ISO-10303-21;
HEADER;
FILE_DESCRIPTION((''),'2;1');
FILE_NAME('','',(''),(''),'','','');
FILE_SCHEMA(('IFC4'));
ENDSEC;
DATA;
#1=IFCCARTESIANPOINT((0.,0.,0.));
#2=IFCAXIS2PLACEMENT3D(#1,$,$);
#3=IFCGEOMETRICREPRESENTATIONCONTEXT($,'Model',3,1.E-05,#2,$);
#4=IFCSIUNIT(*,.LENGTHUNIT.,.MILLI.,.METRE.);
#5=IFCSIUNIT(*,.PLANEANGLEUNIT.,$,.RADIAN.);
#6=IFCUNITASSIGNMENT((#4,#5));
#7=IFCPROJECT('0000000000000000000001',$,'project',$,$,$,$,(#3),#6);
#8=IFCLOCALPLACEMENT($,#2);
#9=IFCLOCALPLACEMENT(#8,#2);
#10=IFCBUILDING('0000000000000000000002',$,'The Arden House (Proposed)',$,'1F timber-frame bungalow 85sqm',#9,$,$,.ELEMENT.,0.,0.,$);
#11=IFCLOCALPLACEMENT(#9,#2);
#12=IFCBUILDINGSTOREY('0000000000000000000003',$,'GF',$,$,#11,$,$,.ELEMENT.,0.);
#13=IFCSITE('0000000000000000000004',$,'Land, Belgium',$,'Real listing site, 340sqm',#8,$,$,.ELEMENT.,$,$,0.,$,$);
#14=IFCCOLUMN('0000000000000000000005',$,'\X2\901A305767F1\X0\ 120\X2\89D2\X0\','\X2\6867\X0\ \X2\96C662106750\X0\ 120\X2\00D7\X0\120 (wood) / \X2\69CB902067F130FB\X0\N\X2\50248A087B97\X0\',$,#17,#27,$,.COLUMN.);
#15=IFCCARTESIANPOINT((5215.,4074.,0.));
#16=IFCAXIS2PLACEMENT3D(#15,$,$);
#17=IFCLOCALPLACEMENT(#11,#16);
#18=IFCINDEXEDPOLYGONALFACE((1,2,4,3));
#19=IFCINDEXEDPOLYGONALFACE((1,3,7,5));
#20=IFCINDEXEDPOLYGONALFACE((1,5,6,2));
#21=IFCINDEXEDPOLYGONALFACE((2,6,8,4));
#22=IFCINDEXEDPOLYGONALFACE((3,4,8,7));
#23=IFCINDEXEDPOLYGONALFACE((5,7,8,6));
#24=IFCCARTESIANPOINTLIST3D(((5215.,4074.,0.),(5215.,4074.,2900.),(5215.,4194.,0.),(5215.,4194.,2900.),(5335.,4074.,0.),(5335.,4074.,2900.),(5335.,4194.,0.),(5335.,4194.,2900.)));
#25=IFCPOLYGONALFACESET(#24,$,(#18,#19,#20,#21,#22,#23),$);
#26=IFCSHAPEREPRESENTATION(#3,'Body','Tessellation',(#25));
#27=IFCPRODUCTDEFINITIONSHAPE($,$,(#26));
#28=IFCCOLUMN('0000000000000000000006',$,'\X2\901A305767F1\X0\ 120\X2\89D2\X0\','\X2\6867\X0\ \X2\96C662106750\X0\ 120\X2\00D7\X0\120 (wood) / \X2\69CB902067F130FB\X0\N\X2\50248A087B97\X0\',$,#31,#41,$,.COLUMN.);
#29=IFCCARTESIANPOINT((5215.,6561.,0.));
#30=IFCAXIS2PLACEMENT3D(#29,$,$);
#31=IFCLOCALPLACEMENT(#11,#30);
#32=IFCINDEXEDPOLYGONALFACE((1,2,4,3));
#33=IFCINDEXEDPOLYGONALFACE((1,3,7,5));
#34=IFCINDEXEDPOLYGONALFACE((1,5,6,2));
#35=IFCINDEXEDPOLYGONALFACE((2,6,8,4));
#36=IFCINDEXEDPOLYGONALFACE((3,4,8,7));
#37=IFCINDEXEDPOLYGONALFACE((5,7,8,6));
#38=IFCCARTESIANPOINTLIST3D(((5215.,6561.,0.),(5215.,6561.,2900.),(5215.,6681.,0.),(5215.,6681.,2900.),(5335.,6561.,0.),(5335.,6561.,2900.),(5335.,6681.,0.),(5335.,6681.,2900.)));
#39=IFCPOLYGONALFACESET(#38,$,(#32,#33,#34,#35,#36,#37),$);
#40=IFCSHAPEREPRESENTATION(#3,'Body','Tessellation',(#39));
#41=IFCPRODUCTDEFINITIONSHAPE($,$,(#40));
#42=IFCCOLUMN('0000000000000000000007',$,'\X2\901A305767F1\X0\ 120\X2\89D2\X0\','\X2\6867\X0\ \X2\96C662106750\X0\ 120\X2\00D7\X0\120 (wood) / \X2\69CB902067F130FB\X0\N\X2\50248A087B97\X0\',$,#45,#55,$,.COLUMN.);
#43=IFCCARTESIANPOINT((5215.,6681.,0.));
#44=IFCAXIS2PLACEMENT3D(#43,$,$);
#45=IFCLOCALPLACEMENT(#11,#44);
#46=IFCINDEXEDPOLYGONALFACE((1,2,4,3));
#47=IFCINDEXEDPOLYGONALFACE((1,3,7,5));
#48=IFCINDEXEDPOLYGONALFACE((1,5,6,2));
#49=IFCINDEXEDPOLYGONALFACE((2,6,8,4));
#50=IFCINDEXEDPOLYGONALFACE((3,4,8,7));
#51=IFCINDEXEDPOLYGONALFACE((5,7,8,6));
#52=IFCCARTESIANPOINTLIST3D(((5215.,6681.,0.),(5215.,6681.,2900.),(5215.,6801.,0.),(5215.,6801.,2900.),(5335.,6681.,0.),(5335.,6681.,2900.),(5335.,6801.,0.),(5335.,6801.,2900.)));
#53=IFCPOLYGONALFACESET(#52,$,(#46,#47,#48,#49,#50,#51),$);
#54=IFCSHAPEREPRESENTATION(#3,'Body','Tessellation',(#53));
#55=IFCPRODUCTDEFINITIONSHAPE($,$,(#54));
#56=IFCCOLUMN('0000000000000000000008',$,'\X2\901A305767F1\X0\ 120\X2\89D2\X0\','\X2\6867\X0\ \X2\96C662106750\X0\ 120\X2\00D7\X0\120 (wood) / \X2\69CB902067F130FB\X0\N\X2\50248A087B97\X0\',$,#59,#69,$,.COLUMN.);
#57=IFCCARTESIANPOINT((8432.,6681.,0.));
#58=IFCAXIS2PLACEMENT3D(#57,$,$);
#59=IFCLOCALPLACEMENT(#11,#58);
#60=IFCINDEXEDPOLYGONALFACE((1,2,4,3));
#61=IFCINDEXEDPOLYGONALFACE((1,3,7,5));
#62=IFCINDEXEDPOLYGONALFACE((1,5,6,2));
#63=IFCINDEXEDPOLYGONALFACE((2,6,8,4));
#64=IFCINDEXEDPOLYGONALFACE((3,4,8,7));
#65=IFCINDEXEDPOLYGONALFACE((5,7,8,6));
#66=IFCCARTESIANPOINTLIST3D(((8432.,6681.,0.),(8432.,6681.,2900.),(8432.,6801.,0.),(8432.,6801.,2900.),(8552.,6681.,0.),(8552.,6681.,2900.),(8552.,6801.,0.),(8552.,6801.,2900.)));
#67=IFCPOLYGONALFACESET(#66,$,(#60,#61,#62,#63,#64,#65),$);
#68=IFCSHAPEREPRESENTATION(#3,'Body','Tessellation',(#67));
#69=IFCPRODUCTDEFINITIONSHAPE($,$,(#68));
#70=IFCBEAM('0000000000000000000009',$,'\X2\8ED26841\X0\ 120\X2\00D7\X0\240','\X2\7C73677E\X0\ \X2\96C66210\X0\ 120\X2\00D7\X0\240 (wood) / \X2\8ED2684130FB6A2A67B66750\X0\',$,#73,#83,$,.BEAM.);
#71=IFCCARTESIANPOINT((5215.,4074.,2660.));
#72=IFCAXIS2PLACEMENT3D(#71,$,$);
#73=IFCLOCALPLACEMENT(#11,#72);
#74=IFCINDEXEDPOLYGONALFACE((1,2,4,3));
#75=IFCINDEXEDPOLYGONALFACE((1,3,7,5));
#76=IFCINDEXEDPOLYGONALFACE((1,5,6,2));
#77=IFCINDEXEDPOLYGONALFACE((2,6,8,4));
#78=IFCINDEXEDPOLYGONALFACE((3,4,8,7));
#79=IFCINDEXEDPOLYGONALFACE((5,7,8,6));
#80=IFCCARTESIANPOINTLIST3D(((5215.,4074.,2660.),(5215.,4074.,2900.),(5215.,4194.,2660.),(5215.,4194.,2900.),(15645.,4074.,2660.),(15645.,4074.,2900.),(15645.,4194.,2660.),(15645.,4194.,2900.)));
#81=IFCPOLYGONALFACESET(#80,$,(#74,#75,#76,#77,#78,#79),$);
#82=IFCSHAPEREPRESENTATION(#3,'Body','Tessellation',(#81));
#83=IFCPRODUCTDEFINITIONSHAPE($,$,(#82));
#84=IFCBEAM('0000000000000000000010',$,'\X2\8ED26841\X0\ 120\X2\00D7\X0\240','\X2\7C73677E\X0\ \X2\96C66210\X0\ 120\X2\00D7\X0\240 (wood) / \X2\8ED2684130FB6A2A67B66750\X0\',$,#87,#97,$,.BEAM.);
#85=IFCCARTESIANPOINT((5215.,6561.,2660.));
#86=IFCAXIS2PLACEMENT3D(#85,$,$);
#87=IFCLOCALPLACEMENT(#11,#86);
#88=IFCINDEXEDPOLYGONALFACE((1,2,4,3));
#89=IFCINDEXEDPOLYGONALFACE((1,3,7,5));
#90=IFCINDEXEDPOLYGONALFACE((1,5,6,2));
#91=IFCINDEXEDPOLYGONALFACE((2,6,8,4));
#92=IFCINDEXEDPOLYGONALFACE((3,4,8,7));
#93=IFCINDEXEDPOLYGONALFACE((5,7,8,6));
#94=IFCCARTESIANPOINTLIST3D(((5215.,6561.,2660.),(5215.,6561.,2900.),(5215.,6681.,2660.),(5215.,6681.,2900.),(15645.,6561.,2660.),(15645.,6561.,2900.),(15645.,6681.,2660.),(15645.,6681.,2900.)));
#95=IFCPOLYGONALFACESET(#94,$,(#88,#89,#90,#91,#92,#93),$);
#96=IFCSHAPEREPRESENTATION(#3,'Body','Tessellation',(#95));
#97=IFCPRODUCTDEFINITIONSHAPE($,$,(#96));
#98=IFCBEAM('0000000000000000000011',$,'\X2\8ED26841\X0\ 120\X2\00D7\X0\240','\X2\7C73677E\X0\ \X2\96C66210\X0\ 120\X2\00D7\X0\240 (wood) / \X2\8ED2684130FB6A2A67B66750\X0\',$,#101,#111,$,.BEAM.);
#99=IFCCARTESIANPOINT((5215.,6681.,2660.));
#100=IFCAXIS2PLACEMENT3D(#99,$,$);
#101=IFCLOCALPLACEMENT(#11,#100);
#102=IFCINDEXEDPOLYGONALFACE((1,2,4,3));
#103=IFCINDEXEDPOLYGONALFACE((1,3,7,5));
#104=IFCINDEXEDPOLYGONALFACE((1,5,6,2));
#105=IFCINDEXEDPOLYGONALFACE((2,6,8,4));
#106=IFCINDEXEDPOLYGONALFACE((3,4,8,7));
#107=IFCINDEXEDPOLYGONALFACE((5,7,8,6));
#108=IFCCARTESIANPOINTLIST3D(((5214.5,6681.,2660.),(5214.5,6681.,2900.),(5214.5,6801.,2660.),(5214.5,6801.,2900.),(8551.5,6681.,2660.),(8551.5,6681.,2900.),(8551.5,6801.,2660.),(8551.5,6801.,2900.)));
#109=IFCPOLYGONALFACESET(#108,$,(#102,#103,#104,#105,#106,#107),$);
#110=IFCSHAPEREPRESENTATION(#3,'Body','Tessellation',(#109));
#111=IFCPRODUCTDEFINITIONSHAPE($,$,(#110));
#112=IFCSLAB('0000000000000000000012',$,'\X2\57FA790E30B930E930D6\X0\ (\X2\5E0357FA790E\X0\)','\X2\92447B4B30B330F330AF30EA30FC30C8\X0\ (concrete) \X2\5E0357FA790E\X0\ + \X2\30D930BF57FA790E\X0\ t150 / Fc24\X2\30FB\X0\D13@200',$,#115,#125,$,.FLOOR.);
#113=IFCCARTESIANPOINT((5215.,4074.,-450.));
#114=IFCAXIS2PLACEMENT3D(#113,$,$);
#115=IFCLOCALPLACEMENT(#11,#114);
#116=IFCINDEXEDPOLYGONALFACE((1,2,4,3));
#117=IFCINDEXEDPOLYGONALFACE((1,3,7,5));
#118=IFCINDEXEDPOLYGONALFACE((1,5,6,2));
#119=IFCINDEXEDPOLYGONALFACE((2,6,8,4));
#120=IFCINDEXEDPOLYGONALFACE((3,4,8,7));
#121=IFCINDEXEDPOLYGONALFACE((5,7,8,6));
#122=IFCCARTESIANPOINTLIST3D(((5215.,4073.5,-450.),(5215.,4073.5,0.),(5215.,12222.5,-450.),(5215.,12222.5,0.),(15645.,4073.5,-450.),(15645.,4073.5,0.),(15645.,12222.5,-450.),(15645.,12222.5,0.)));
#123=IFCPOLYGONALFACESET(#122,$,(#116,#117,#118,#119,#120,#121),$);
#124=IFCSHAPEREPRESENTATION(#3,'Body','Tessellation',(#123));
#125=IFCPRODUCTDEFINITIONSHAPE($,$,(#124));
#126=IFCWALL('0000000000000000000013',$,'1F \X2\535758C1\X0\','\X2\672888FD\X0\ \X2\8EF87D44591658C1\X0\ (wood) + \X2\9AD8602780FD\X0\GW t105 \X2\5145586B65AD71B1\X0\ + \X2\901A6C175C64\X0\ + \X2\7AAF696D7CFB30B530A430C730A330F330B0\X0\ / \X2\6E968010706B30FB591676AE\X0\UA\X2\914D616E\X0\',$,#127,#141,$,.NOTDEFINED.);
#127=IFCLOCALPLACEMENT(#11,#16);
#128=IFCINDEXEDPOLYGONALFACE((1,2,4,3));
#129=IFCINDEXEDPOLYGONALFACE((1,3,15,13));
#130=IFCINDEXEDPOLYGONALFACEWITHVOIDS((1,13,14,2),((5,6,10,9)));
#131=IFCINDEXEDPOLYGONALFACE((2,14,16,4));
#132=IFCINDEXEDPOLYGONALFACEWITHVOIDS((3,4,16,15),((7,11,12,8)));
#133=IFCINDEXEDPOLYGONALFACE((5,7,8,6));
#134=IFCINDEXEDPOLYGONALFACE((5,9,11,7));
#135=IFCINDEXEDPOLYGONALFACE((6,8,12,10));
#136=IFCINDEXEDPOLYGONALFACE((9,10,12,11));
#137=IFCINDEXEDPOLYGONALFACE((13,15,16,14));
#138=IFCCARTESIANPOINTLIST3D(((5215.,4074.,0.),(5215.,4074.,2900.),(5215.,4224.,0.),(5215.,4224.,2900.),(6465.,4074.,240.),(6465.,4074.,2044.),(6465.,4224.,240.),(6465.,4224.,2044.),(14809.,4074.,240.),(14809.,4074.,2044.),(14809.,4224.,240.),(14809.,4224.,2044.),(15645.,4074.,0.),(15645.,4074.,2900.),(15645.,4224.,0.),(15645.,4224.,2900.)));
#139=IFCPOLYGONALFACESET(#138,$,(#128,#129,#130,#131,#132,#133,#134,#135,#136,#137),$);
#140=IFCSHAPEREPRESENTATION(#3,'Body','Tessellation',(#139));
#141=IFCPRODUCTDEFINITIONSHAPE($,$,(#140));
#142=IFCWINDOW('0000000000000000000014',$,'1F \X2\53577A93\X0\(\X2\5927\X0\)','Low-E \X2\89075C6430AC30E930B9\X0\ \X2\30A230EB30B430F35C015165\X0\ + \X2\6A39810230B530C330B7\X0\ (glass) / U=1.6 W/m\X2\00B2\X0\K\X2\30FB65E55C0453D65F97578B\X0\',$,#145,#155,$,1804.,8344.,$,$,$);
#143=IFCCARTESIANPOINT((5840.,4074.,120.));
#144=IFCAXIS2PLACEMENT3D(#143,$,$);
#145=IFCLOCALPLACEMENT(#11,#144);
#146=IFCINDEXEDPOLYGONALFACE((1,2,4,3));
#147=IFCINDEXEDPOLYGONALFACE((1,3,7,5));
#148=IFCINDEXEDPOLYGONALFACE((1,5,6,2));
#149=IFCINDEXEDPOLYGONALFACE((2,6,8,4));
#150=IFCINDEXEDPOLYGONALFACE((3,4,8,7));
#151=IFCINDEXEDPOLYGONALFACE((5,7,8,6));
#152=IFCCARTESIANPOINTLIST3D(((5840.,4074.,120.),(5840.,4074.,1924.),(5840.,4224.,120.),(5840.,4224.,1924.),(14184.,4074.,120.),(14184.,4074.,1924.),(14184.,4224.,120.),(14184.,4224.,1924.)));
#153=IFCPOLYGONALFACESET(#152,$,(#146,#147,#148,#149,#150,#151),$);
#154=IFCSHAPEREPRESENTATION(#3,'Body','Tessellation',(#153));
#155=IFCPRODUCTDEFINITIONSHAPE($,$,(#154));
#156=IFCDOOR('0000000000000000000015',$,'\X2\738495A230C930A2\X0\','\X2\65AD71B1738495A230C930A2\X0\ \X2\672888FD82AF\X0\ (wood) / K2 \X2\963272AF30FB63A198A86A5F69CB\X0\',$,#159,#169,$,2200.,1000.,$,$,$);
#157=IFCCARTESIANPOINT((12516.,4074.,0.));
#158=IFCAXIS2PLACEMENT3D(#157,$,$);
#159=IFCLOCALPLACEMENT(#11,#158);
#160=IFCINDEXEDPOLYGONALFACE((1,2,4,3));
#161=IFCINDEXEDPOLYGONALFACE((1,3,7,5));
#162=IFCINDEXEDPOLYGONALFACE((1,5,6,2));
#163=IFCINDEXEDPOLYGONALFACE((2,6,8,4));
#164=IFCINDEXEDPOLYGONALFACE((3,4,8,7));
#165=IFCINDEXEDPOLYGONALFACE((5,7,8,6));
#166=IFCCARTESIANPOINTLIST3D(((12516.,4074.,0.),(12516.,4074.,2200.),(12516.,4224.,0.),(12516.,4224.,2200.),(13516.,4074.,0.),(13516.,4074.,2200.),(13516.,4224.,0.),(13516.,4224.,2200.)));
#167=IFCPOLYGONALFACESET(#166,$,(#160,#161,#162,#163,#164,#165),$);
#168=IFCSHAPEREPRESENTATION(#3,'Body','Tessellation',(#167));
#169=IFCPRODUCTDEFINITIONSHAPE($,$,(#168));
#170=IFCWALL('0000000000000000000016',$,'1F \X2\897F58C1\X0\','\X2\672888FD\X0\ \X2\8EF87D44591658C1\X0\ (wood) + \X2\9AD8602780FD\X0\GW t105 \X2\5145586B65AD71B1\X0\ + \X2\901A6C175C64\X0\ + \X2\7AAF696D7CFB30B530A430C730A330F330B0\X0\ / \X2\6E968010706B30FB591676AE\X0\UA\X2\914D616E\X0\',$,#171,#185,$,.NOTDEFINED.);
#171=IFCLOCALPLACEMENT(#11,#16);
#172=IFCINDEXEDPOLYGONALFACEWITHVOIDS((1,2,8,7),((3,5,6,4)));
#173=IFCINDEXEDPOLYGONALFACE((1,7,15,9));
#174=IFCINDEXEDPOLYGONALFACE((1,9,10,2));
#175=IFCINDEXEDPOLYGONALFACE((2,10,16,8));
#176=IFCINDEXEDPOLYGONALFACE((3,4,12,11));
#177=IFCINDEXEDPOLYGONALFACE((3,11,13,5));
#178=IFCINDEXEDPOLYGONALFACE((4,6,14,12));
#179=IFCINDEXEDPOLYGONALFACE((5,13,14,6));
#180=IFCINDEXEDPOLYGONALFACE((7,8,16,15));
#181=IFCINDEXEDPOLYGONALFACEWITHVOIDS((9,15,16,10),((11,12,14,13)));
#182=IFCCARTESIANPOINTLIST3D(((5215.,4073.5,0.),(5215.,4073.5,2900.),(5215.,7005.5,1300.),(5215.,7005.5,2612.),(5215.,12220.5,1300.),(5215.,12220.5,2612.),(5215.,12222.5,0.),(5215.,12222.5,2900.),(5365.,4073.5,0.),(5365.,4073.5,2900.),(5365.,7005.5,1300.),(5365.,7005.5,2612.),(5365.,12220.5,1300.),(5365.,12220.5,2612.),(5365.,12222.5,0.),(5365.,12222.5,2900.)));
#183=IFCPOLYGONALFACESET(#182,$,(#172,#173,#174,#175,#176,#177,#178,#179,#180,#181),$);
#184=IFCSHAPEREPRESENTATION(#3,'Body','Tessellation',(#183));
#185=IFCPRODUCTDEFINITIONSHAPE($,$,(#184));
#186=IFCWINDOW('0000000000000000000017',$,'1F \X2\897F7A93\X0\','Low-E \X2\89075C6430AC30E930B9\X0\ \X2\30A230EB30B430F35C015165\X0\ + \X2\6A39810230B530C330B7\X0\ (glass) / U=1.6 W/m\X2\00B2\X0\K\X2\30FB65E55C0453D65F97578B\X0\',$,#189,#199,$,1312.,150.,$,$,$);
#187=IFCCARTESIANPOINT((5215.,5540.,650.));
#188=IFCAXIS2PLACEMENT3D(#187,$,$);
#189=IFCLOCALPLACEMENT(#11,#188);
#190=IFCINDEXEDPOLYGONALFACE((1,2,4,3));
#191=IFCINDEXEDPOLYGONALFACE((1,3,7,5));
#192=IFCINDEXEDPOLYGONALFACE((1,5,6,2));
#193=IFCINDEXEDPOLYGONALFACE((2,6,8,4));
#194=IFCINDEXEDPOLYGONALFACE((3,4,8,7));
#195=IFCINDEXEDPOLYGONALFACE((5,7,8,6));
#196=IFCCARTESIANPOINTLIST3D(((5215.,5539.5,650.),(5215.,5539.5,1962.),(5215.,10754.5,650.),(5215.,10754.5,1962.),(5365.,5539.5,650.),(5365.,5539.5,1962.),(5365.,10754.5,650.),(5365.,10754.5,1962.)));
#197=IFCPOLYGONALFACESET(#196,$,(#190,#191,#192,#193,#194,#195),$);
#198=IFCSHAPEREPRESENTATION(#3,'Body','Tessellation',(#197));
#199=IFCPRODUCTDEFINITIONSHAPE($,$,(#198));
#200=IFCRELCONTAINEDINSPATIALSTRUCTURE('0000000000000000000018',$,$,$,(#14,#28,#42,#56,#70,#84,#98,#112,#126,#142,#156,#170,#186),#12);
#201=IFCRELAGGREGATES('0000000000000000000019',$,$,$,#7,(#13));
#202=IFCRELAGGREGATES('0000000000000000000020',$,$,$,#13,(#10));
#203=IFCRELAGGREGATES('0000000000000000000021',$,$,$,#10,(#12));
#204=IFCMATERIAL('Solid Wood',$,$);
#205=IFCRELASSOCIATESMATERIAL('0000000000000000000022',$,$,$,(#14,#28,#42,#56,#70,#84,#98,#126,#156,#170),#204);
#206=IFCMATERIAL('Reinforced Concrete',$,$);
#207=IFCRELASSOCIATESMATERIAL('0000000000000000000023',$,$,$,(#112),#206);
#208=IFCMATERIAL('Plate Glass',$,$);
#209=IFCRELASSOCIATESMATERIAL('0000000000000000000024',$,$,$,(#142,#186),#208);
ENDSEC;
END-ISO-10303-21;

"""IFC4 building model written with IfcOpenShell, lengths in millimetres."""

from ifc_helpers import new_model, si_unit, frame, frame_2d, origin, place, context, project, spatial, rectangle, extrude, material, element, fill, save


model = new_model("IFC4")

# Units and contexts
model_context = context("Model", 3, precision=1e-05, world=origin())
ifc_project = project(units=[si_unit("LENGTHUNIT", "METRE", prefix="MILLI"), si_unit("PLANEANGLEUNIT", "RADIAN")], contexts=[model_context])

# Site, building, storey
site_placement = place(None, origin())
site = spatial("IfcSite", under=ifc_project, at=site_placement, Name="Land, Belgium", ObjectType="Real listing site, 340sqm", CompositionType="ELEMENT", RefElevation=0.0)
building_placement = place(site_placement, origin())
building = spatial("IfcBuilding", under=site, at=building_placement, Name="The Arden House (Proposed)", ObjectType="1F timber-frame bungalow 85sqm", CompositionType="ELEMENT", ElevationOfRefHeight=0.0, ElevationOfTerrain=0.0)
storey_placement = place(building_placement, origin())
storey = spatial("IfcBuildingStorey", under=building, at=storey_placement, Name="GF", CompositionType="ELEMENT", Elevation=0.0)

# Columns
ifc_material_1 = material(Name="Solid Wood")
column_1_placement = place(storey_placement, frame((5215.0, 4074.0, 0.0)))
element("IfcColumn", 1, at=column_1_placement, inside=storey, material=ifc_material_1, Name="通し柱 120角", Description="桧 集成材 120×120 (wood) / 構造柱・N値計算", PredefinedType="COLUMN", context=model_context, shape_type="SweptSolid", body=[
    extrude(rectangle(XDim=120.0, YDim=120.0, at=frame_2d((60.0, 60.0))), frame((5215.0, 4074.0, 0.0)), (0.0, 0.0, 1.0), 2900.0),
])
column_2_placement = place(storey_placement, frame((5215.0, 6561.0, 0.0)))
element("IfcColumn", 2, at=column_2_placement, inside=storey, material=ifc_material_1, Name="通し柱 120角", Description="桧 集成材 120×120 (wood) / 構造柱・N値計算", PredefinedType="COLUMN", context=model_context, shape_type="SweptSolid", body=[
    extrude(rectangle(XDim=120.0, YDim=120.0, at=frame_2d((60.0, 60.0))), frame((5215.0, 6561.0, 0.0)), (0.0, 0.0, 1.0), 2900.0),
])
column_3_placement = place(storey_placement, frame((5215.0, 6681.0, 0.0)))
element("IfcColumn", 3, at=column_3_placement, inside=storey, material=ifc_material_1, Name="通し柱 120角", Description="桧 集成材 120×120 (wood) / 構造柱・N値計算", PredefinedType="COLUMN", context=model_context, shape_type="SweptSolid", body=[
    extrude(rectangle(XDim=120.0, YDim=120.0, at=frame_2d((60.0, 60.0))), frame((5215.0, 6681.0, 0.0)), (0.0, 0.0, 1.0), 2900.0),
])
column_4_placement = place(storey_placement, frame((8432.0, 6681.0, 0.0)))
element("IfcColumn", 4, at=column_4_placement, inside=storey, material=ifc_material_1, Name="通し柱 120角", Description="桧 集成材 120×120 (wood) / 構造柱・N値計算", PredefinedType="COLUMN", context=model_context, shape_type="SweptSolid", body=[
    extrude(rectangle(XDim=120.0, YDim=120.0, at=frame_2d((60.0, 60.0))), frame((8432.0, 6681.0, 0.0)), (0.0, 0.0, 1.0), 2900.0),
])

# Beams
beam_1_placement = place(storey_placement, frame((5215.0, 4074.0, 2660.0)))
element("IfcBeam", 5, at=beam_1_placement, inside=storey, material=ifc_material_1, Name="軒桁 120×240", Description="米松 集成 120×240 (wood) / 軒桁・横架材", PredefinedType="BEAM", context=model_context, shape_type="SweptSolid", body=[
    extrude(rectangle(XDim=10430.0, YDim=120.0, at=frame_2d((5215.0, 60.0))), frame((5215.0, 4074.0, 2660.0)), (0.0, 0.0, 1.0), 240.0),
])
beam_2_placement = place(storey_placement, frame((5215.0, 6561.0, 2660.0)))
element("IfcBeam", 6, at=beam_2_placement, inside=storey, material=ifc_material_1, Name="軒桁 120×240", Description="米松 集成 120×240 (wood) / 軒桁・横架材", PredefinedType="BEAM", context=model_context, shape_type="SweptSolid", body=[
    extrude(rectangle(XDim=10430.0, YDim=120.0, at=frame_2d((5215.0, 60.0))), frame((5215.0, 6561.0, 2660.0)), (0.0, 0.0, 1.0), 240.0),
])
beam_3_placement = place(storey_placement, frame((5215.0, 6681.0, 2660.0)))
element("IfcBeam", 7, at=beam_3_placement, inside=storey, material=ifc_material_1, Name="軒桁 120×240", Description="米松 集成 120×240 (wood) / 軒桁・横架材", PredefinedType="BEAM", context=model_context, shape_type="SweptSolid", body=[
    extrude(rectangle(XDim=3337.0, YDim=120.0, at=frame_2d((1668.0, 60.0))), frame((5215.0, 6681.0, 2660.0)), (0.0, 0.0, 1.0), 240.0),
])

# Slab
ifc_material_2 = material(Name="Reinforced Concrete")
slab_1_placement = place(storey_placement, frame((5215.0, 4074.0, -450.0)))
element("IfcSlab", 8, at=slab_1_placement, inside=storey, material=ifc_material_2, Name="基礎スラブ (布基礎)", Description="鉄筋コンクリート (concrete) 布基礎 + ベタ基礎 t150 / Fc24・D13@200", PredefinedType="FLOOR", context=model_context, shape_type="SweptSolid", body=[
    extrude(rectangle(XDim=10430.0, YDim=8149.0, at=frame_2d((5215.0, 4074.0))), frame((5215.0, 4074.0, -450.0)), (0.0, 0.0, 1.0), 450.0),
])

# Wall, openings, window, door
wall_1_placement = place(storey_placement, frame((5215.0, 4074.0, 0.0)))
wall_1 = element("IfcWall", 9, at=wall_1_placement, inside=storey, material=ifc_material_1, Name="1F 南壁", Description="木製 軸組外壁 (wood) + 高性能GW t105 充填断熱 + 通気層 + 窯業系サイディング / 準耐火・外皮UA配慮", PredefinedType="NOTDEFINED", context=model_context, shape_type="SweptSolid", body=[
    extrude(rectangle(XDim=10430.0, YDim=150.0, at=frame_2d((5215.0, 75.0))), frame((5215.0, 4074.0, 0.0)), (0.0, 0.0, 1.0), 2900.0),
])
opening_1_placement = place(storey_placement, frame((5840.0, 4074.0, 120.0)))
opening_1 = element("IfcOpeningElement", 10, at=opening_1_placement, cuts=wall_1, PredefinedType="NOTDEFINED", context=model_context, shape_type="SweptSolid", body=[
    extrude(rectangle(XDim=8344.0, YDim=150.0, at=frame_2d((4172.0, 75.0))), frame((5840.0, 4074.0, 120.0)), (0.0, 0.0, 1.0), 1804.0),
])
opening_2_placement = place(storey_placement, frame((12516.0, 4074.0, 0.0)))
opening_2 = element("IfcOpeningElement", 11, at=opening_2_placement, cuts=wall_1, PredefinedType="NOTDEFINED", context=model_context, shape_type="SweptSolid", body=[
    extrude(rectangle(XDim=1000.0, YDim=150.0, at=frame_2d((500.0, 75.0))), frame((12516.0, 4074.0, 0.0)), (0.0, 0.0, 1.0), 2200.0),
])
ifc_material_3 = material(Name="Plate Glass")
window_1_placement = place(storey_placement, frame((5840.0, 4074.0, 120.0)))
window_1 = element("IfcWindow", 12, at=window_1_placement, inside=storey, material=ifc_material_3, Name="1F 南窓(大)", Description="Low-E 複層ガラス アルゴン封入 + 樹脂サッシ (glass) / U=1.6 W/m²K・日射取得型", OverallHeight=1804.0, OverallWidth=8344.0, context=model_context, shape_type="SweptSolid", body=[
    extrude(rectangle(XDim=8344.0, YDim=150.0, at=frame_2d((4172.0, 75.0))), frame((5840.0, 4074.0, 120.0)), (0.0, 0.0, 1.0), 1804.0),
])
fill(opening_1, window_1)
door_placement = place(storey_placement, frame((12516.0, 4074.0, 0.0)))
door = element("IfcDoor", 13, at=door_placement, inside=storey, material=ifc_material_1, Name="玄関ドア", Description="断熱玄関ドア 木製芯 (wood) / K2 防犯・採風機構", OverallHeight=2200.0, OverallWidth=1000.0, context=model_context, shape_type="SweptSolid", body=[
    extrude(rectangle(XDim=1000.0, YDim=150.0, at=frame_2d((500.0, 75.0))), frame((12516.0, 4074.0, 0.0)), (0.0, 0.0, 1.0), 2200.0),
])
fill(opening_2, door)

# Wall, opening, window
wall_2_placement = place(storey_placement, frame((5215.0, 4074.0, 0.0)))
wall_2 = element("IfcWall", 14, at=wall_2_placement, inside=storey, material=ifc_material_1, Name="1F 西壁", Description="木製 軸組外壁 (wood) + 高性能GW t105 充填断熱 + 通気層 + 窯業系サイディング / 準耐火・外皮UA配慮", PredefinedType="NOTDEFINED", context=model_context, shape_type="SweptSolid", body=[
    extrude(rectangle(XDim=150.0, YDim=8149.0, at=frame_2d((75.0, 4074.0))), frame((5215.0, 4074.0, 0.0)), (0.0, 0.0, 1.0), 2900.0),
])
opening_3_placement = place(storey_placement, frame((5215.0, 5540.0, 650.0)))
opening_3 = element("IfcOpeningElement", 15, at=opening_3_placement, cuts=wall_2, PredefinedType="NOTDEFINED", context=model_context, shape_type="SweptSolid", body=[
    extrude(rectangle(XDim=150.0, YDim=5215.0, at=frame_2d((75.0, 2607.0))), frame((5215.0, 5540.0, 650.0)), (0.0, 0.0, 1.0), 1312.0),
])
window_2_placement = place(storey_placement, frame((5215.0, 5540.0, 650.0)))
window_2 = element("IfcWindow", 16, at=window_2_placement, inside=storey, material=ifc_material_3, Name="1F 西窓", Description="Low-E 複層ガラス アルゴン封入 + 樹脂サッシ (glass) / U=1.6 W/m²K・日射取得型", OverallHeight=1312.0, OverallWidth=150.0, context=model_context, shape_type="SweptSolid", body=[
    extrude(rectangle(XDim=150.0, YDim=5215.0, at=frame_2d((75.0, 2607.0))), frame((5215.0, 5540.0, 650.0)), (0.0, 0.0, 1.0), 1312.0),
])
fill(opening_3, window_2)

save(model, "model.ifc")
